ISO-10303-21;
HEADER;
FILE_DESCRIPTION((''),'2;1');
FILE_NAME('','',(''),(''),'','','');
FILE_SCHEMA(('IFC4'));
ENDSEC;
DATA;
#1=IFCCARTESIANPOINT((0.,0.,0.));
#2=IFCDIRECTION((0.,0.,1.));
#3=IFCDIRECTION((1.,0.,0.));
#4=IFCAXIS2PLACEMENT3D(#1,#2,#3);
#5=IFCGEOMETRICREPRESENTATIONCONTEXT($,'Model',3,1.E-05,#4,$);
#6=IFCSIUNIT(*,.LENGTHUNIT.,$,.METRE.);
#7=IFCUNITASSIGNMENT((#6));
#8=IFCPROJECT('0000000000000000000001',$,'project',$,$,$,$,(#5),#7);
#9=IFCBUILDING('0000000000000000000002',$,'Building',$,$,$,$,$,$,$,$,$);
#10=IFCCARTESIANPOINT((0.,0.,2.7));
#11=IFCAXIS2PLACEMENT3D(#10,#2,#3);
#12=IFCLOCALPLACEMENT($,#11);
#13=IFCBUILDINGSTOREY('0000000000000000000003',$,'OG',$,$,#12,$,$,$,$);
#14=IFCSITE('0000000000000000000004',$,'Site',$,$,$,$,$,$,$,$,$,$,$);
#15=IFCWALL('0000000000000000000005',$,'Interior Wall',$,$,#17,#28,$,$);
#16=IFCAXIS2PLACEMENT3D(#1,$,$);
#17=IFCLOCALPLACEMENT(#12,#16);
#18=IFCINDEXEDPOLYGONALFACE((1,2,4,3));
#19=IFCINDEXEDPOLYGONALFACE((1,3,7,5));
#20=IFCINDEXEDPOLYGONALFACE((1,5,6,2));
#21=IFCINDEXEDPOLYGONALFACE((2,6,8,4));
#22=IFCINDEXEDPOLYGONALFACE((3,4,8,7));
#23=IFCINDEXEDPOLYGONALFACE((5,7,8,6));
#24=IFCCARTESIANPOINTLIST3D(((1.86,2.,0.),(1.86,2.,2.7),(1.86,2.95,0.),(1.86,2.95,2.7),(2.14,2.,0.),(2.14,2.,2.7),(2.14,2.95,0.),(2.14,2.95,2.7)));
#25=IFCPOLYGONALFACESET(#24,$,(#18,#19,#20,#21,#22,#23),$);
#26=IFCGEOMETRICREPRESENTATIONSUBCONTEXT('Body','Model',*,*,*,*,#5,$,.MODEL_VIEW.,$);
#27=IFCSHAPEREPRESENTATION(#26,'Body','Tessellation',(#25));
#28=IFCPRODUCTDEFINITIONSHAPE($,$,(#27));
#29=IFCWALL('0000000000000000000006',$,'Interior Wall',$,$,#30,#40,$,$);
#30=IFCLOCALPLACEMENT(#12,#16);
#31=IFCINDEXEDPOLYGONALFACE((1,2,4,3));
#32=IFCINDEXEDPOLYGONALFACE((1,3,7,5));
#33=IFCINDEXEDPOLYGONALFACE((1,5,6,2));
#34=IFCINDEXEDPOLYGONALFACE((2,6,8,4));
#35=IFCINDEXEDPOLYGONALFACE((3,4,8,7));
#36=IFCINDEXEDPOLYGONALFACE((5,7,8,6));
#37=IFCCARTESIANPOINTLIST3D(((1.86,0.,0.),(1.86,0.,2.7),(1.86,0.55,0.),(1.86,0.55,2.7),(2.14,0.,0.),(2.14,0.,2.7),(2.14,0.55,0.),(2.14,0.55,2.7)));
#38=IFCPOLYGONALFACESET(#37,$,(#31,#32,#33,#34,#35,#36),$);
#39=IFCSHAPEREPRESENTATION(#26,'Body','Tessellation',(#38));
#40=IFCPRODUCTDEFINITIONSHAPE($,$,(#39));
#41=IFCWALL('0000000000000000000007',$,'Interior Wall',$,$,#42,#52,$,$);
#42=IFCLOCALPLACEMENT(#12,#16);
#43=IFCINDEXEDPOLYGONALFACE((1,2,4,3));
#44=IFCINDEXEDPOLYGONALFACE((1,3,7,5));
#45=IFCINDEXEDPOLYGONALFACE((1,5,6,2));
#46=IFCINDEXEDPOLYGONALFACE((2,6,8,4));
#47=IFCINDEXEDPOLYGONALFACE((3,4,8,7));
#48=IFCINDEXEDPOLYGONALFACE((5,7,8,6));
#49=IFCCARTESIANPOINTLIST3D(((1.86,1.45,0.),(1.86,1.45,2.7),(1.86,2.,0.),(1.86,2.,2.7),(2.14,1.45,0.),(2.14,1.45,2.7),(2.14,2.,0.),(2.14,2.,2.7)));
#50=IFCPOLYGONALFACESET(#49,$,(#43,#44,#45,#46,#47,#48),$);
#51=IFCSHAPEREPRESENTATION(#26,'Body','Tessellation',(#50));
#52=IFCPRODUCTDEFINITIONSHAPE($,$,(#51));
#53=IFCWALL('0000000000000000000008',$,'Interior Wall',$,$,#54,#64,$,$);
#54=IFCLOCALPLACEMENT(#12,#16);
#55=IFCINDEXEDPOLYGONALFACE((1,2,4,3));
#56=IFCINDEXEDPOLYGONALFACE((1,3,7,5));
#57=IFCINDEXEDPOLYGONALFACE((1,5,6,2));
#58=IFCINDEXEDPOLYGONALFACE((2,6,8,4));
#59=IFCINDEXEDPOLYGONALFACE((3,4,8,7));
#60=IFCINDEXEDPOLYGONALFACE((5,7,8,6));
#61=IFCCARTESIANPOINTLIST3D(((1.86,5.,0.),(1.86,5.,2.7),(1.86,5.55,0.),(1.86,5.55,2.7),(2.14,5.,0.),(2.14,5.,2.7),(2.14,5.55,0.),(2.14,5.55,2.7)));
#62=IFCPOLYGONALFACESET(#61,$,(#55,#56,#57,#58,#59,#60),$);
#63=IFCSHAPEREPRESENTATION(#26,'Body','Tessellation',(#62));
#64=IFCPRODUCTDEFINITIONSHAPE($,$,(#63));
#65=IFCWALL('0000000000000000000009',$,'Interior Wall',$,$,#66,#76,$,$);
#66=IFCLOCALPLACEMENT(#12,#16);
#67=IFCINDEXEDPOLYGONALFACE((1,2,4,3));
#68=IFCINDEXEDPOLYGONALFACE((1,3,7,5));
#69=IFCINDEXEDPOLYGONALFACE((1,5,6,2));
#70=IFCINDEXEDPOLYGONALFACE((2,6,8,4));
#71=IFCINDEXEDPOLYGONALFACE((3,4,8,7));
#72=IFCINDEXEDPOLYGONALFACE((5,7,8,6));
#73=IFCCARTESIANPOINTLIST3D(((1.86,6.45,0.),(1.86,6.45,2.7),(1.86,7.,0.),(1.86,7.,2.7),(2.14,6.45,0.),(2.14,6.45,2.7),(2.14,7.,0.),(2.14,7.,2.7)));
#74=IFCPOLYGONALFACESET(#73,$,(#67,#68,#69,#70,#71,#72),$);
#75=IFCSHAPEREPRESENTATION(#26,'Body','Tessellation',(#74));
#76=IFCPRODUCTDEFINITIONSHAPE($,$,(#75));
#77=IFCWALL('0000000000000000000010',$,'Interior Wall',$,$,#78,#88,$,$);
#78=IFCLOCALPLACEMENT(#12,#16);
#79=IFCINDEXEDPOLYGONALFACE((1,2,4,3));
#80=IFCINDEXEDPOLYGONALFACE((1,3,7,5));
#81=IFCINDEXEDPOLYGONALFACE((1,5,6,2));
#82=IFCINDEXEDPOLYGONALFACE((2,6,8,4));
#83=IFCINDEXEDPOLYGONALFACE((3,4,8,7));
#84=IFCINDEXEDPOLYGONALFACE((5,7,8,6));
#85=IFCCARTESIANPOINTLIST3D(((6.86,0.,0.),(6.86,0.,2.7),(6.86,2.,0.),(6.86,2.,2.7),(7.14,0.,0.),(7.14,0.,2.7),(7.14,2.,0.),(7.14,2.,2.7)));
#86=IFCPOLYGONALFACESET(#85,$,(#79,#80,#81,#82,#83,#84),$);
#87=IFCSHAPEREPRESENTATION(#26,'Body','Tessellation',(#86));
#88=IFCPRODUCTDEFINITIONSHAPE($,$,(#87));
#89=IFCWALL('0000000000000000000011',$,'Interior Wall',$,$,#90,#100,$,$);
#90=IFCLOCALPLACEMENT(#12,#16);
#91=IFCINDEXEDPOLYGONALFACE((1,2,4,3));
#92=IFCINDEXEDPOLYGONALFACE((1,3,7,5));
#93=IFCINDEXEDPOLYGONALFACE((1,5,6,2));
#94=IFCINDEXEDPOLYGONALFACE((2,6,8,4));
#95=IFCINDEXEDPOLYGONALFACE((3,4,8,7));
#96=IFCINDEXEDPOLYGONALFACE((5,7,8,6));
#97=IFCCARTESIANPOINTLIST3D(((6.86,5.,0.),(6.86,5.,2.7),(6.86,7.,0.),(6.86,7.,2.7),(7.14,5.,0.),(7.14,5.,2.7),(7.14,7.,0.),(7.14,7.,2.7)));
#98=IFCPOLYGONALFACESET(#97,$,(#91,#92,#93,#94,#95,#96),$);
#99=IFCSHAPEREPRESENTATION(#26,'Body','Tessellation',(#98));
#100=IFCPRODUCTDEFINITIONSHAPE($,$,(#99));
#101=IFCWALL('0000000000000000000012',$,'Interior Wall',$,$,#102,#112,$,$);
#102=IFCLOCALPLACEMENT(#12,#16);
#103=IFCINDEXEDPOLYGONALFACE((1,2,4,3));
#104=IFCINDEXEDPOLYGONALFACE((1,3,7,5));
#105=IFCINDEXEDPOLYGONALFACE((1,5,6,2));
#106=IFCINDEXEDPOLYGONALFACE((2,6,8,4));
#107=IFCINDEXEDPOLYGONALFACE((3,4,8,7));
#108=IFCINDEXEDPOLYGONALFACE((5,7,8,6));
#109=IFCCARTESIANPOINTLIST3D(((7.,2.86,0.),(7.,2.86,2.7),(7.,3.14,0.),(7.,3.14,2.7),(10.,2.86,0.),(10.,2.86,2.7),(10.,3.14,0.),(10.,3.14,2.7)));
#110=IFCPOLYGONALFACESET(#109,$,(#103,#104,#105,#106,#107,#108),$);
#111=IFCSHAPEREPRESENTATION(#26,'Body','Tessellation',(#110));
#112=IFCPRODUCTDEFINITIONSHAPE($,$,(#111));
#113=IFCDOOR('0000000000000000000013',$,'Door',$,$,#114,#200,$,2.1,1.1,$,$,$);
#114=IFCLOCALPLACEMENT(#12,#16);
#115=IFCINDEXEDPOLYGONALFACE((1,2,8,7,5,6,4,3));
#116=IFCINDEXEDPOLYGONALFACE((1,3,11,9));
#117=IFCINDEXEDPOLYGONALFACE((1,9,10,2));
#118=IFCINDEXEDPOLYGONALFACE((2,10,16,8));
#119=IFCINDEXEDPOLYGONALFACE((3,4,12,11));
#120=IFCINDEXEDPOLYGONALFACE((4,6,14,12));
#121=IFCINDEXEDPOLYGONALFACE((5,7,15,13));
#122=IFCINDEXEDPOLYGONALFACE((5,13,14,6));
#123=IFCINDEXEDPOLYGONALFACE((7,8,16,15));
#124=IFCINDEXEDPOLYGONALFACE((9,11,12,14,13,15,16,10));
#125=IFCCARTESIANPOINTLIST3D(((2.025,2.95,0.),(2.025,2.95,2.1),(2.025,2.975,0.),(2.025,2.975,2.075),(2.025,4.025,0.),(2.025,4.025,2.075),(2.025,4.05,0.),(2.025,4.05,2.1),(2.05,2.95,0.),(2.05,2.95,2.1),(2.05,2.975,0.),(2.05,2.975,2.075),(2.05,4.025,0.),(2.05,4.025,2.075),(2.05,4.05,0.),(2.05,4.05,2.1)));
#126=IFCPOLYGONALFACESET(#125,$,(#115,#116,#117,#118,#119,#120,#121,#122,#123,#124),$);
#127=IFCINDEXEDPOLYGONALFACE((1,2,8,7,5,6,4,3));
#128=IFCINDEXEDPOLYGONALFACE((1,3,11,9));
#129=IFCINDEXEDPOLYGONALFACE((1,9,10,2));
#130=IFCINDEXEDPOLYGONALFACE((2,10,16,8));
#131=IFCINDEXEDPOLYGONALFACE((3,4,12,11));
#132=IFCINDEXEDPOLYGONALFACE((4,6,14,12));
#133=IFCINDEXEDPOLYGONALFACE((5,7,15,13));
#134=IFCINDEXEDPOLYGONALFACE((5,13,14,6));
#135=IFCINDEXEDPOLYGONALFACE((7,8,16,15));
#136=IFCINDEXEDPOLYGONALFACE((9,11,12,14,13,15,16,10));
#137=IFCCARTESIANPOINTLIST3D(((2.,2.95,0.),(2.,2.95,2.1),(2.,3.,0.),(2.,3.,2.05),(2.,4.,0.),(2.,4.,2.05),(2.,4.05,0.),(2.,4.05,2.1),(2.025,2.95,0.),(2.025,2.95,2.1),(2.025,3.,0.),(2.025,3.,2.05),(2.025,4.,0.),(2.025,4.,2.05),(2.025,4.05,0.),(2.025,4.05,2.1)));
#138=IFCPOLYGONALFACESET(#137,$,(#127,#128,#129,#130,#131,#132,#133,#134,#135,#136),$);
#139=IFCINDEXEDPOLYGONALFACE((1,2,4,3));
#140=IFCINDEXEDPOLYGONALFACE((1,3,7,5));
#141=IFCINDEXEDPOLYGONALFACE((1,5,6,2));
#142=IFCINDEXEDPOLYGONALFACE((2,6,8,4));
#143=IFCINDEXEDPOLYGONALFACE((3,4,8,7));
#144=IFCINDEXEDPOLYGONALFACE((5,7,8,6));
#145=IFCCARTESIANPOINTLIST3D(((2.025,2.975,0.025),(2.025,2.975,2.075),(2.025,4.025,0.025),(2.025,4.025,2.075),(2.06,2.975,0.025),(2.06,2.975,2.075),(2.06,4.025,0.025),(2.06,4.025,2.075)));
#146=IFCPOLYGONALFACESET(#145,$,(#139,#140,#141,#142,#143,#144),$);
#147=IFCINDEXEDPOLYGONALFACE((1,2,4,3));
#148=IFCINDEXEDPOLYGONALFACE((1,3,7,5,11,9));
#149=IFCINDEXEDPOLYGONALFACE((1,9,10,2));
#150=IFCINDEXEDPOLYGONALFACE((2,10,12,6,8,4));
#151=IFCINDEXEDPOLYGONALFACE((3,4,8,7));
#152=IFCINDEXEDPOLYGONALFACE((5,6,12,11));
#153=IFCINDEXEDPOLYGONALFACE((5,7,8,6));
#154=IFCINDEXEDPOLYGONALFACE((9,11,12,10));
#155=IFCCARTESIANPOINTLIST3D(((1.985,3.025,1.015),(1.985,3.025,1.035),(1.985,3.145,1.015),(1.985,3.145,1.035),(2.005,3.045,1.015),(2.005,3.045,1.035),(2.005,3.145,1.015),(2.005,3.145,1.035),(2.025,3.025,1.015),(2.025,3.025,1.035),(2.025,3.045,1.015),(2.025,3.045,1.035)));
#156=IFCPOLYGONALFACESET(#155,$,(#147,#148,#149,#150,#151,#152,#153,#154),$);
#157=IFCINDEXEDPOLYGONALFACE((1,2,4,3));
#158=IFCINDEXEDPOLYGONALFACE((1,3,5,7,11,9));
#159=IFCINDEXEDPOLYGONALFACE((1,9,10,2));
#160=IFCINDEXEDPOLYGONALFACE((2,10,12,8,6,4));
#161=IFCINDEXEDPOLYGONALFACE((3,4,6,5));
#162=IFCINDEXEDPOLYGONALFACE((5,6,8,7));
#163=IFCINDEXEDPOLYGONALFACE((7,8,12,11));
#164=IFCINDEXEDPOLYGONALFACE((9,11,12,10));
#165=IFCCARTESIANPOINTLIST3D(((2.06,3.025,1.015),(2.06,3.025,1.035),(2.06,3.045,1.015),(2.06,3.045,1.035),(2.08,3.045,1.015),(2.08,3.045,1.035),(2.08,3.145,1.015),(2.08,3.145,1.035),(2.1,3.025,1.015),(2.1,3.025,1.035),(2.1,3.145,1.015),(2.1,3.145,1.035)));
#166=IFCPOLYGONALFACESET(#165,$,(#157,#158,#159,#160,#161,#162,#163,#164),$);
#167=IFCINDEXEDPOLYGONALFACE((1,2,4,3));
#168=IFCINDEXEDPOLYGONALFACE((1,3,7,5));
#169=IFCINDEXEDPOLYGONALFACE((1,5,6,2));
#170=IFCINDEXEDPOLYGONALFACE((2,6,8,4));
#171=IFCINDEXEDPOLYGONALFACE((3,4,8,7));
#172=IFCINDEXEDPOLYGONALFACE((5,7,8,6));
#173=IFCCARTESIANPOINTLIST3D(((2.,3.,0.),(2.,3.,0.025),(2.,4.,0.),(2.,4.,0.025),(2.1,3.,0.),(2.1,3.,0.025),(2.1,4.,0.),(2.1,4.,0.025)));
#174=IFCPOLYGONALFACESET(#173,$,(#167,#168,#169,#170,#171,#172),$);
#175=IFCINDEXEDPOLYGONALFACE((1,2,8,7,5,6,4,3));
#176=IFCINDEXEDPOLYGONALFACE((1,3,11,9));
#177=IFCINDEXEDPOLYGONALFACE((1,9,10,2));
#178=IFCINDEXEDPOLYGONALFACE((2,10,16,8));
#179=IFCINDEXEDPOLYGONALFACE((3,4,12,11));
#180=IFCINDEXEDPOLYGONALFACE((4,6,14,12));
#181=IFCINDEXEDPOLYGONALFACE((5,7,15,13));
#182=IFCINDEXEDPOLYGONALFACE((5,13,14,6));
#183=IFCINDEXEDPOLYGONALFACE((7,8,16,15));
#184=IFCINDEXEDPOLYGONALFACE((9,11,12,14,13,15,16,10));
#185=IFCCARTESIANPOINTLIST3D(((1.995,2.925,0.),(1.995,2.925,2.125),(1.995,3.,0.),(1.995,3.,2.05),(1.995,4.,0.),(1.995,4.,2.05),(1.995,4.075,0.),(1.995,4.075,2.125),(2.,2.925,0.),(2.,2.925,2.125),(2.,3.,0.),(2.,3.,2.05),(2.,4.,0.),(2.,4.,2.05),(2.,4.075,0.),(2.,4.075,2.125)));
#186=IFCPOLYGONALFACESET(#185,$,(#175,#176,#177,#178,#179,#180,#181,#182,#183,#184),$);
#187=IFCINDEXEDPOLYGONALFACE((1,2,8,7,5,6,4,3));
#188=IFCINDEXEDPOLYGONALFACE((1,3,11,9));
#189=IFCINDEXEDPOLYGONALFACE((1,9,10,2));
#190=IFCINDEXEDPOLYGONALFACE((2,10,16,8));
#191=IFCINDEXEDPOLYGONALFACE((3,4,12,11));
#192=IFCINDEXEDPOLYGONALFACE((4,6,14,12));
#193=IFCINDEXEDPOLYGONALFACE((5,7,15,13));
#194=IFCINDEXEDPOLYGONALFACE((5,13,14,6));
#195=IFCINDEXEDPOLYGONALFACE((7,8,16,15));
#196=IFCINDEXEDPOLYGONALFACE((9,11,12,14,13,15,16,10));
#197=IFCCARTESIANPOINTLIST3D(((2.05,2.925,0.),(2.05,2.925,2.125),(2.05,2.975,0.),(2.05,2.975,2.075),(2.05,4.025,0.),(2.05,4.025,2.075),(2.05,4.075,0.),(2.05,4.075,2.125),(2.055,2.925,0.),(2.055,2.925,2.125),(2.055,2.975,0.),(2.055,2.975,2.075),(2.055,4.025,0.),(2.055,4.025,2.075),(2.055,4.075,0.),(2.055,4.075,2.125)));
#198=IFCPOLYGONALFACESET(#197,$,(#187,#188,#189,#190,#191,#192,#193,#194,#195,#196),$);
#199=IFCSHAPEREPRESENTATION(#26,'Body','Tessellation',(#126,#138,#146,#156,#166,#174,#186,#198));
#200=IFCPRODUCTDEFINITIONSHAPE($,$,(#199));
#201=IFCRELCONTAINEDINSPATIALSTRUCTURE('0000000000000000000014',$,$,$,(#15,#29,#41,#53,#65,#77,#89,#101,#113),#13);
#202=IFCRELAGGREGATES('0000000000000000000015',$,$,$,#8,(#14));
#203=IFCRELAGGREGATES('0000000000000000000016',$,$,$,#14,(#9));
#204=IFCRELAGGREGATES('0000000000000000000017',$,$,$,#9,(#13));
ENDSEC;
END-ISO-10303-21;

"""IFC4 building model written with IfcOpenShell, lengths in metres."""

from ifc_helpers import new_model, si_unit, frame, origin_with_axes, place, context, subcontext, project, spatial, line, indexed_curve, outline, extrude, element, save


model = new_model("IFC4")

# Units and contexts
model_context = context("Model", 3, precision=1e-05, world=origin_with_axes())
body_context = subcontext(model_context, "Body", "Model", "MODEL_VIEW")
ifc_project = project(units=[si_unit("LENGTHUNIT", "METRE")], contexts=[model_context])

# Site, building, storey
site = spatial("IfcSite", under=ifc_project, Name="Site")
building = spatial("IfcBuilding", under=site, Name="Building")
storey_placement = place(None, frame((0.0, 0.0, 2.7), z_axis=(0.0, 0.0, 1.0), x_axis=(1.0, 0.0, 0.0)))
storey = spatial("IfcBuildingStorey", under=building, at=storey_placement, Name="OG")

# Walls
for number, where, z_axis, x_axis, name in (
    (1, (2.0, 2.95, 0.0), (0.0, 0.0, 1.0), (0.0, -1.0, 0.0), "Interior Wall"),
):
    element("IfcWall", number, at=place(storey_placement, frame(where, z_axis=z_axis, x_axis=x_axis)), inside=storey, Name=name, context=body_context, shape_type="SweptSolid", body=[
        extrude(outline(indexed_curve([(0.0, 0.0), (0.0, 0.28), (0.95, 0.28), (0.95, 0.0), (0.0, 0.0)], self_intersect=False)), frame((0.0, -0.14, 0.0), z_axis=(0.0, 0.0, 1.0), x_axis=(1.0, 0.0, 0.0)), (0.0, 0.0, 1.0), 2.7),
    ])
for number, where, z_axis, x_axis, name in (
    (2, (2.0, 0.0, 0.0), (0.0, 0.0, 1.0), (0.0, 1.0, 0.0), "Interior Wall"),
    (3, (2.0, 1.45, 0.0), (0.0, 0.0, 1.0), (0.0, 1.0, 0.0), "Interior Wall"),
):
    element("IfcWall", number, at=place(storey_placement, frame(where, z_axis=z_axis, x_axis=x_axis)), inside=storey, Name=name, context=body_context, shape_type="SweptSolid", body=[
        extrude(outline(indexed_curve([(0.0, 0.0), (0.0, 0.28), (0.55, 0.28), (0.55, 0.0), (0.0, 0.0)], self_intersect=False)), frame((0.0, -0.14, 0.0), z_axis=(0.0, 0.0, 1.0), x_axis=(1.0, 0.0, 0.0)), (0.0, 0.0, 1.0), 2.7),
    ])
for number, where, z_axis, x_axis, name in (
    (4, (2.0, 5.0, 0.0), (0.0, 0.0, 1.0), (0.0, 1.0, 0.0), "Interior Wall"),
    (5, (2.0, 6.45, 0.0), (0.0, 0.0, 1.0), (0.0, 1.0, 0.0), "Interior Wall"),
):
    element("IfcWall", number, at=place(storey_placement, frame(where, z_axis=z_axis, x_axis=x_axis)), inside=storey, Name=name, context=body_context, shape_type="SweptSolid", body=[
        extrude(outline(indexed_curve([(0.0, 0.0), (0.0, 0.28), (0.55, 0.28), (0.55, 0.0), (0.0, 0.0)], self_intersect=False)), frame((0.0, -0.14, 0.0), z_axis=(0.0, 0.0, 1.0), x_axis=(1.0, 0.0, 0.0)), (0.0, 0.0, 1.0), 2.7),
    ])
for number, where, z_axis, x_axis, name in (
    (6, (7.0, 0.0, 0.0), (0.0, 0.0, 1.0), (0.0, 1.0, 0.0), "Interior Wall"),
    (7, (7.0, 5.0, 0.0), (0.0, 0.0, 1.0), (0.0, 1.0, 0.0), "Interior Wall"),
):
    element("IfcWall", number, at=place(storey_placement, frame(where, z_axis=z_axis, x_axis=x_axis)), inside=storey, Name=name, context=body_context, shape_type="SweptSolid", body=[
        extrude(outline(indexed_curve([(0.0, 0.0), (0.0, 0.28), (2.0, 0.28), (2.0, 0.0), (0.0, 0.0)], self_intersect=False)), frame((0.0, -0.14, 0.0), z_axis=(0.0, 0.0, 1.0), x_axis=(1.0, 0.0, 0.0)), (0.0, 0.0, 1.0), 2.7),
    ])
wall_1_placement = place(storey_placement, frame((10.0, 3.0, 0.0), z_axis=(0.0, 0.0, 1.0), x_axis=(-1.0, 0.0, 0.0)))
element("IfcWall", 8, at=wall_1_placement, inside=storey, Name="Interior Wall", context=body_context, shape_type="SweptSolid", body=[
    extrude(outline(indexed_curve([(0.0, 0.0), (0.0, 0.28), (3.0, 0.28), (3.0, 0.0), (0.0, 0.0)], self_intersect=False)), frame((0.0, -0.14, 0.0), z_axis=(0.0, 0.0, 1.0), x_axis=(1.0, 0.0, 0.0)), (0.0, 0.0, 1.0), 2.7),
])

# Door
door_1_placement = place(storey_placement, frame((2.0, 4.05, 0.0), z_axis=(0.0, 0.0, 1.0), x_axis=(0.0, -1.0, 0.0)))
element("IfcDoor", 9, at=door_1_placement, inside=storey, Name="Door", OverallHeight=2.1, OverallWidth=1.1, context=body_context, shape_type="SweptSolid", body=[
    extrude(outline(indexed_curve([(0.0, 0.0), (0.0, 2.1), (1.1, 2.1), (1.1, 0.0), (1.075, 0.0), (1.075, 2.075), (0.025, 2.075), (0.025, 0.0)], segments=[line(1, 2, 3, 4, 5, 6, 7, 8, 1)])), frame((0.0, 0.025, 0.0), z_axis=(0.0, -1.0, 0.0), x_axis=(1.0, 0.0, 0.0)), (0.0, 0.0, -1.0), 0.025),
    extrude(outline(indexed_curve([(0.0, 0.0), (0.0, 2.1), (1.1, 2.1), (1.1, 0.0), (1.05, 0.0), (1.05, 2.05), (0.05, 2.05), (0.05, 0.0)], segments=[line(1, 2, 3, 4, 5, 6, 7, 8, 1)])), frame((0.0, 0.0, 0.0), z_axis=(0.0, -1.0, 0.0), x_axis=(1.0, 0.0, 0.0)), (0.0, 0.0, -1.0), 0.025),
    extrude(outline(indexed_curve([(0.0, 0.0), (1.05, 0.0), (1.05, 0.035), (0.0, 0.035)], segments=[line(1, 2, 3, 4, 1)])), frame((0.025, 0.025, 0.025), z_axis=(0.0, 0.0, 1.0), x_axis=(1.0, 0.0, 0.0)), (0.0, 0.0, 1.0), 2.05),
    extrude(outline(indexed_curve([(0.0, 0.0), (0.0, -0.04), (-0.12, -0.04), (-0.12, -0.02), (-0.02, -0.02), (-0.02, 0.0)], segments=[line(1, 2, 3, 4, 5, 6, 1)])), frame((1.025, 0.025, 1.015), z_axis=(0.0, 0.0, 1.0), x_axis=(1.0, 0.0, 0.0)), (0.0, 0.0, 1.0), 0.02),
    extrude(outline(indexed_curve([(0.0, 0.0), (0.0, 0.04), (-0.12, 0.04), (-0.12, 0.02), (-0.02, 0.02), (-0.02, 0.0)], segments=[line(1, 2, 3, 4, 5, 6, 1)])), frame((1.025, 0.06, 1.015), z_axis=(0.0, 0.0, 1.0), x_axis=(1.0, 0.0, 0.0)), (0.0, 0.0, 1.0), 0.02),
    extrude(outline(indexed_curve([(0.0, 0.0), (1.0, 0.0), (1.0, 0.1), (0.0, 0.1)], segments=[line(1, 2, 3, 4, 1)])), frame((0.05, 0.0, 0.0), z_axis=(0.0, 0.0, 1.0), x_axis=(1.0, 0.0, 0.0)), (0.0, 0.0, 1.0), 0.025),
    extrude(outline(indexed_curve([(0.0, 0.0), (0.0, 2.125), (1.15, 2.125), (1.15, 0.0), (1.075, 0.0), (1.075, 2.05), (0.075, 2.05), (0.075, 0.0)], segments=[line(1, 2, 3, 4, 5, 6, 7, 8, 1)])), frame((-0.025, -0.005, 0.0), z_axis=(0.0, -1.0, 0.0), x_axis=(1.0, 0.0, 0.0)), (0.0, 0.0, -1.0), 0.005),
    extrude(outline(indexed_curve([(0.0, 0.0), (0.0, 2.125), (1.15, 2.125), (1.15, 0.0), (1.1, 0.0), (1.1, 2.075), (0.05, 2.075), (0.05, 0.0)], segments=[line(1, 2, 3, 4, 5, 6, 7, 8, 1)])), frame((-0.025, 0.05, 0.0), z_axis=(0.0, -1.0, 0.0), x_axis=(1.0, 0.0, 0.0)), (0.0, 0.0, -1.0), 0.005),
])

save(model, "model.ifc")
